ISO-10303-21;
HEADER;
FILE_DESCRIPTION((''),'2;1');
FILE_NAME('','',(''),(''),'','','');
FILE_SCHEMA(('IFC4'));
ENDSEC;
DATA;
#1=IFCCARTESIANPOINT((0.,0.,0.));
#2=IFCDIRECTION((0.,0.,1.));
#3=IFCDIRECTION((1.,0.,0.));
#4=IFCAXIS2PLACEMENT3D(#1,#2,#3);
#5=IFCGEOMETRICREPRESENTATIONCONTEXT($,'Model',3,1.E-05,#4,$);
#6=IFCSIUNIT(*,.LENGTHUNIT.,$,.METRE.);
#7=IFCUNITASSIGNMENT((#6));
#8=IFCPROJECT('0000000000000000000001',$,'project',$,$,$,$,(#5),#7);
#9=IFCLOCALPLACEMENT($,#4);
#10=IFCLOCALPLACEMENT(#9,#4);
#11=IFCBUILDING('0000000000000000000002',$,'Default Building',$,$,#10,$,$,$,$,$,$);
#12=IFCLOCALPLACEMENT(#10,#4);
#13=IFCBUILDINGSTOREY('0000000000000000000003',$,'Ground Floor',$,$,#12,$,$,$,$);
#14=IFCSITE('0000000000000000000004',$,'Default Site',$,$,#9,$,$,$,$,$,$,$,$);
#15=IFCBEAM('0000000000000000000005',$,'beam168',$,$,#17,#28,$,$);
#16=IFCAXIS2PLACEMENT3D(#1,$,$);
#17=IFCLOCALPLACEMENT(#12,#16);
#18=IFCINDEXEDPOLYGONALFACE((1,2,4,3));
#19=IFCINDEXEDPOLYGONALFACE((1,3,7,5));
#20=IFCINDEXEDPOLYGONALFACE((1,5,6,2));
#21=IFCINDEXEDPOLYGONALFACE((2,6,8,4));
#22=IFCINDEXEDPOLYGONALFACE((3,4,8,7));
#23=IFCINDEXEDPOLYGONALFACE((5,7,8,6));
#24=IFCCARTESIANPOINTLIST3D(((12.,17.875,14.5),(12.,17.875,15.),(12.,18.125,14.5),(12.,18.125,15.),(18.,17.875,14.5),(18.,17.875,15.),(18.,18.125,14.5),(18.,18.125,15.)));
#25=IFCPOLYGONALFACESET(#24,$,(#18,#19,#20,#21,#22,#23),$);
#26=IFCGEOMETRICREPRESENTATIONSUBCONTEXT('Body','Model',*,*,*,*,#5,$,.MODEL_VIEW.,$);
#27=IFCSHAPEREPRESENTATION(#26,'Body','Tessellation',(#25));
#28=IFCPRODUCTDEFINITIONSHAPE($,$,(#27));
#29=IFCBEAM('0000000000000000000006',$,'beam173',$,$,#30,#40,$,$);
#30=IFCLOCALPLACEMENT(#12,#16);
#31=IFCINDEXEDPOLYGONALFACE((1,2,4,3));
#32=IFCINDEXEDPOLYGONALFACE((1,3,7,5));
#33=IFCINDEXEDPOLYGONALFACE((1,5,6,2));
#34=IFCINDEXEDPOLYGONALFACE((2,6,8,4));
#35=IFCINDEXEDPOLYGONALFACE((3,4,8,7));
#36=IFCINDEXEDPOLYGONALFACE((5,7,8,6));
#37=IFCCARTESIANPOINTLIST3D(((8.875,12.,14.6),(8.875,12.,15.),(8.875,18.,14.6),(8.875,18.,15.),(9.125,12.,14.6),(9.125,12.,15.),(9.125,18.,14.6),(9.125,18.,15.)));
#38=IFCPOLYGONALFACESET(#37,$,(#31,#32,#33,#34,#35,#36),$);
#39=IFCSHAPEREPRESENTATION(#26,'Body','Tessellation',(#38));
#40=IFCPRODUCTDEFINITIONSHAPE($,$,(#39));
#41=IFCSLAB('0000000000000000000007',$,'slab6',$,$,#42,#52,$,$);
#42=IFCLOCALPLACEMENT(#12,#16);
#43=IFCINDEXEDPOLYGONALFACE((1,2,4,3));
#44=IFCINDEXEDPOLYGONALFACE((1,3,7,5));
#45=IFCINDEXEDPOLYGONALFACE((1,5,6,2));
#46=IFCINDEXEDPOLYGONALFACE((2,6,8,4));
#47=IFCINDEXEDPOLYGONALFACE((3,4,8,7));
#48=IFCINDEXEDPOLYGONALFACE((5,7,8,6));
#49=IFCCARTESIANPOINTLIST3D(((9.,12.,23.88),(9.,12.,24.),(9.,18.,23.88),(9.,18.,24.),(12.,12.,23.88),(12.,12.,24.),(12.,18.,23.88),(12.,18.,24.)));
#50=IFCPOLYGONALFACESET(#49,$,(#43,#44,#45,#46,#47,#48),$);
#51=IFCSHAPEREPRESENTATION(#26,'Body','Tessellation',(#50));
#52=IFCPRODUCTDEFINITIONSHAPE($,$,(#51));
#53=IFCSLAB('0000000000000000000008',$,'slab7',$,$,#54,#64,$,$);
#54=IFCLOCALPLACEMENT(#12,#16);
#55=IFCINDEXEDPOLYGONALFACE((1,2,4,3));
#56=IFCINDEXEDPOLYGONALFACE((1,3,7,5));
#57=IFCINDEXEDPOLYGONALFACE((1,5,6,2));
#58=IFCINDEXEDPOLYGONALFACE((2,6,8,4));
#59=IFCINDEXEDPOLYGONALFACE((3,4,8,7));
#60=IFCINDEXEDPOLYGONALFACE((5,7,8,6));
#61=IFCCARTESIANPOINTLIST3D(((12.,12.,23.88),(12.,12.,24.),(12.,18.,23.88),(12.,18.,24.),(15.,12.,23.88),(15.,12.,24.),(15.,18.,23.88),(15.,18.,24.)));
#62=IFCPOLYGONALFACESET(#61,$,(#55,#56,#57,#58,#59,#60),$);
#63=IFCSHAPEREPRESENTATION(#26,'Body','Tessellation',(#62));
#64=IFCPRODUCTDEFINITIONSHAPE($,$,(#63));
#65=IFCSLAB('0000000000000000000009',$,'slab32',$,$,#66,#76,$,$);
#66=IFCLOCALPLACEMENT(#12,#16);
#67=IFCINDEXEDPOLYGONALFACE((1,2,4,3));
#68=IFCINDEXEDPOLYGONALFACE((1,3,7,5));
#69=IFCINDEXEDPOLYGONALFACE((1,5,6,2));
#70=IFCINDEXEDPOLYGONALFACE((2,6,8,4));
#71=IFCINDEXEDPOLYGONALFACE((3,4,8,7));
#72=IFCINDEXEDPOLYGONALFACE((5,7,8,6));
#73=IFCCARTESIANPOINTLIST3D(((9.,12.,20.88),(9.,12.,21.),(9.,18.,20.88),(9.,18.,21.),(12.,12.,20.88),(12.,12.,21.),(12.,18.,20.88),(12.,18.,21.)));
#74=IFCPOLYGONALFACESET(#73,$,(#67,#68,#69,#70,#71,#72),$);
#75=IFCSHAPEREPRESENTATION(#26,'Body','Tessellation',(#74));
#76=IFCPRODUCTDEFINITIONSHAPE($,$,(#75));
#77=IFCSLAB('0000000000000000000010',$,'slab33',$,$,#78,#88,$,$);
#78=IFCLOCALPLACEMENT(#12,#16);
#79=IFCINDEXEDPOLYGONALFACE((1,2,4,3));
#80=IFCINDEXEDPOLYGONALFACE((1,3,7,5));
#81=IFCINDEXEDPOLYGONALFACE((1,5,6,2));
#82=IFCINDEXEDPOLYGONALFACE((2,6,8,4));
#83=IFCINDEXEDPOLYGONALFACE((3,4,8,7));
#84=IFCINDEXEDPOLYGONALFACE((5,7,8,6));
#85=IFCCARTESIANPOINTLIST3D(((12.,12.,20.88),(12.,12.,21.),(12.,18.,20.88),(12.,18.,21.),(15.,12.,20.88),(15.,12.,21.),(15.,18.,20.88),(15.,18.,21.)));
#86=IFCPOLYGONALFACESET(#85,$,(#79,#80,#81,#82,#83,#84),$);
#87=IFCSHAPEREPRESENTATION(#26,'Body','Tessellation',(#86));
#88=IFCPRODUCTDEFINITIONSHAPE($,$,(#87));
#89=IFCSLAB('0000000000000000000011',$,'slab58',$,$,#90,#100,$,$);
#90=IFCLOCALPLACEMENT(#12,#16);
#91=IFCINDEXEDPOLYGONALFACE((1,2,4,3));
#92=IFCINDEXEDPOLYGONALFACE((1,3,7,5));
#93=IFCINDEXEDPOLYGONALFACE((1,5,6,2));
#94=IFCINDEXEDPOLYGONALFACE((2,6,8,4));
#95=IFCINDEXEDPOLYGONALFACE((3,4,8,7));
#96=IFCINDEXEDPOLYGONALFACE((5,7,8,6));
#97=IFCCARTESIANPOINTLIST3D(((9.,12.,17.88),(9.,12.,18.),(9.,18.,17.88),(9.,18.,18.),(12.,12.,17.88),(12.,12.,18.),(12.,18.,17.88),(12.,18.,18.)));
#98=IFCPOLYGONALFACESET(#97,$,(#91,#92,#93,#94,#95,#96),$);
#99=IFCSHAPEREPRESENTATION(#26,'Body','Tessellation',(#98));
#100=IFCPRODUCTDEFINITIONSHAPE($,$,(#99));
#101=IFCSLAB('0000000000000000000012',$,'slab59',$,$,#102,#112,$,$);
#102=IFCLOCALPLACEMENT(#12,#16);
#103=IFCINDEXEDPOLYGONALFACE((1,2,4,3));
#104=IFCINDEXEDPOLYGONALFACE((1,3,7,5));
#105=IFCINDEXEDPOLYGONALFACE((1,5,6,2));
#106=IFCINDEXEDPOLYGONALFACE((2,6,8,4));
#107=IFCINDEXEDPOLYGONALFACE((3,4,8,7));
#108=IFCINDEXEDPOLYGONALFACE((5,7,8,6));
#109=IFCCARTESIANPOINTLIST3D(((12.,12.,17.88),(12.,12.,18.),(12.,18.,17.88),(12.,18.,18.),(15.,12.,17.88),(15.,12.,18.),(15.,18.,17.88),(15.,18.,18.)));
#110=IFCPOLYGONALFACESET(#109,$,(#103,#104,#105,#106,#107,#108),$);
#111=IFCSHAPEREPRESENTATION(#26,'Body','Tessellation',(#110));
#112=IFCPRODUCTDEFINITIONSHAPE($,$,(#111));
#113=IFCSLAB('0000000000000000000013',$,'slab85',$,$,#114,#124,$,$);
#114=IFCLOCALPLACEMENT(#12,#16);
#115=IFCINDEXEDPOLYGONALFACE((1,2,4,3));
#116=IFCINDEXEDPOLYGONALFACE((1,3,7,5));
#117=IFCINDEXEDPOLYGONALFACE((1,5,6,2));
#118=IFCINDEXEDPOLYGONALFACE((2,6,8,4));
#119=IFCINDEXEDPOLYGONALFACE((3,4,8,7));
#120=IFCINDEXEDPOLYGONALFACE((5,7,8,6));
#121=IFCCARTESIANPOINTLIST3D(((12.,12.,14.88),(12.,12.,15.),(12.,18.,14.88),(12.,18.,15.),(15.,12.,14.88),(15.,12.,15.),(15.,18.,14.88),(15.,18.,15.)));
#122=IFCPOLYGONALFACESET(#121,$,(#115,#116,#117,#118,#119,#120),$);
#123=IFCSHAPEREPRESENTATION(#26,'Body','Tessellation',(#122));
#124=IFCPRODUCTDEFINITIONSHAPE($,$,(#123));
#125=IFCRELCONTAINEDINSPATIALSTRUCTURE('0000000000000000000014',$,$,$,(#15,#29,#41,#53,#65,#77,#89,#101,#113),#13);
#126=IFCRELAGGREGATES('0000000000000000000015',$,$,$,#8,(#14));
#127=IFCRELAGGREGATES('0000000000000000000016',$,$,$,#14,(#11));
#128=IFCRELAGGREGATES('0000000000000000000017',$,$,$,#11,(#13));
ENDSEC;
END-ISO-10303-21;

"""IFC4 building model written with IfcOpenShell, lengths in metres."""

from ifc_helpers import new_model, si_unit, frame, origin_with_axes, place, context, subcontext, project, spatial, indexed_curve, outline, extrude, element, save


model = new_model("IFC4")

# Units and contexts
model_context = context("Model", 3, precision=1e-05, world=origin_with_axes())
body_context = subcontext(model_context, "Body", "Model", "MODEL_VIEW")
ifc_project = project(units=[si_unit("LENGTHUNIT", "METRE")], contexts=[model_context])

# Site, building, storey
site_placement = place(None, origin_with_axes())
site = spatial("IfcSite", under=ifc_project, at=site_placement, Name="Default Site")
building_placement = place(site_placement, origin_with_axes())
building = spatial("IfcBuilding", under=site, at=building_placement, Name="Default Building")
storey_placement = place(building_placement, origin_with_axes())
storey = spatial("IfcBuildingStorey", under=building, at=storey_placement, Name="Ground Floor")

# Beams
for number, where, z_axis, x_axis, name in (
    (1, (12.0, 17.875, 14.5), (0.0, 0.0, 1.0), (1.0, 0.0, 0.0), "beam168"),
):
    element("IfcBeam", number, at=place(storey_placement, frame(where, z_axis=z_axis, x_axis=x_axis)), inside=storey, Name=name, context=body_context, shape_type="SweptSolid", body=[
        extrude(outline(indexed_curve([(0.0, 0.0), (0.0, 0.25), (6.0, 0.25), (6.0, 0.0), (0.0, 0.0)], self_intersect=False)), origin_with_axes(), (0.0, 0.0, 1.0), 0.5),
    ])
beam_1_placement = place(storey_placement, frame((8.875, 18.0, 14.6), z_axis=(0.0, 0.0, 1.0), x_axis=(0.0, -1.0, 0.0)))
element("IfcBeam", 2, at=beam_1_placement, inside=storey, Name="beam173", context=body_context, shape_type="SweptSolid", body=[
    extrude(outline(indexed_curve([(0.0, 0.0), (0.0, 0.25), (6.0, 0.25), (6.0, 0.0), (0.0, 0.0)], self_intersect=False)), origin_with_axes(), (0.0, 0.0, 1.0), 0.4),
])

# Slabs
for number, where, z_axis, x_axis, name in (
    (3, (9.0, 12.0, 23.88), (0.0, 0.0, 1.0), (1.0, 0.0, 0.0), "slab6"),
    (4, (12.0, 12.0, 23.88), (0.0, 0.0, 1.0), (1.0, 0.0, 0.0), "slab7"),
    (5, (9.0, 12.0, 20.88), (0.0, 0.0, 1.0), (1.0, 0.0, 0.0), "slab32"),
    (6, (12.0, 12.0, 20.88), (0.0, 0.0, 1.0), (1.0, 0.0, 0.0), "slab33"),
    (7, (9.0, 12.0, 17.88), (0.0, 0.0, 1.0), (1.0, 0.0, 0.0), "slab58"),
    (8, (12.0, 12.0, 17.88), (0.0, 0.0, 1.0), (1.0, 0.0, 0.0), "slab59"),
    (9, (12.0, 12.0, 14.88), (0.0, 0.0, 1.0), (1.0, 0.0, 0.0), "slab85"),
):
    element("IfcSlab", number, at=place(storey_placement, frame(where, z_axis=z_axis, x_axis=x_axis)), inside=storey, Name=name, context=body_context, shape_type="SweptSolid", body=[
        extrude(outline(indexed_curve([(0.0, 0.0), (0.0, 6.0), (3.0, 6.0), (3.0, 0.0), (0.0, 0.0)], self_intersect=False)), origin_with_axes(), (0.0, 0.0, 1.0), 0.12),
    ])

save(model, "model.ifc")
